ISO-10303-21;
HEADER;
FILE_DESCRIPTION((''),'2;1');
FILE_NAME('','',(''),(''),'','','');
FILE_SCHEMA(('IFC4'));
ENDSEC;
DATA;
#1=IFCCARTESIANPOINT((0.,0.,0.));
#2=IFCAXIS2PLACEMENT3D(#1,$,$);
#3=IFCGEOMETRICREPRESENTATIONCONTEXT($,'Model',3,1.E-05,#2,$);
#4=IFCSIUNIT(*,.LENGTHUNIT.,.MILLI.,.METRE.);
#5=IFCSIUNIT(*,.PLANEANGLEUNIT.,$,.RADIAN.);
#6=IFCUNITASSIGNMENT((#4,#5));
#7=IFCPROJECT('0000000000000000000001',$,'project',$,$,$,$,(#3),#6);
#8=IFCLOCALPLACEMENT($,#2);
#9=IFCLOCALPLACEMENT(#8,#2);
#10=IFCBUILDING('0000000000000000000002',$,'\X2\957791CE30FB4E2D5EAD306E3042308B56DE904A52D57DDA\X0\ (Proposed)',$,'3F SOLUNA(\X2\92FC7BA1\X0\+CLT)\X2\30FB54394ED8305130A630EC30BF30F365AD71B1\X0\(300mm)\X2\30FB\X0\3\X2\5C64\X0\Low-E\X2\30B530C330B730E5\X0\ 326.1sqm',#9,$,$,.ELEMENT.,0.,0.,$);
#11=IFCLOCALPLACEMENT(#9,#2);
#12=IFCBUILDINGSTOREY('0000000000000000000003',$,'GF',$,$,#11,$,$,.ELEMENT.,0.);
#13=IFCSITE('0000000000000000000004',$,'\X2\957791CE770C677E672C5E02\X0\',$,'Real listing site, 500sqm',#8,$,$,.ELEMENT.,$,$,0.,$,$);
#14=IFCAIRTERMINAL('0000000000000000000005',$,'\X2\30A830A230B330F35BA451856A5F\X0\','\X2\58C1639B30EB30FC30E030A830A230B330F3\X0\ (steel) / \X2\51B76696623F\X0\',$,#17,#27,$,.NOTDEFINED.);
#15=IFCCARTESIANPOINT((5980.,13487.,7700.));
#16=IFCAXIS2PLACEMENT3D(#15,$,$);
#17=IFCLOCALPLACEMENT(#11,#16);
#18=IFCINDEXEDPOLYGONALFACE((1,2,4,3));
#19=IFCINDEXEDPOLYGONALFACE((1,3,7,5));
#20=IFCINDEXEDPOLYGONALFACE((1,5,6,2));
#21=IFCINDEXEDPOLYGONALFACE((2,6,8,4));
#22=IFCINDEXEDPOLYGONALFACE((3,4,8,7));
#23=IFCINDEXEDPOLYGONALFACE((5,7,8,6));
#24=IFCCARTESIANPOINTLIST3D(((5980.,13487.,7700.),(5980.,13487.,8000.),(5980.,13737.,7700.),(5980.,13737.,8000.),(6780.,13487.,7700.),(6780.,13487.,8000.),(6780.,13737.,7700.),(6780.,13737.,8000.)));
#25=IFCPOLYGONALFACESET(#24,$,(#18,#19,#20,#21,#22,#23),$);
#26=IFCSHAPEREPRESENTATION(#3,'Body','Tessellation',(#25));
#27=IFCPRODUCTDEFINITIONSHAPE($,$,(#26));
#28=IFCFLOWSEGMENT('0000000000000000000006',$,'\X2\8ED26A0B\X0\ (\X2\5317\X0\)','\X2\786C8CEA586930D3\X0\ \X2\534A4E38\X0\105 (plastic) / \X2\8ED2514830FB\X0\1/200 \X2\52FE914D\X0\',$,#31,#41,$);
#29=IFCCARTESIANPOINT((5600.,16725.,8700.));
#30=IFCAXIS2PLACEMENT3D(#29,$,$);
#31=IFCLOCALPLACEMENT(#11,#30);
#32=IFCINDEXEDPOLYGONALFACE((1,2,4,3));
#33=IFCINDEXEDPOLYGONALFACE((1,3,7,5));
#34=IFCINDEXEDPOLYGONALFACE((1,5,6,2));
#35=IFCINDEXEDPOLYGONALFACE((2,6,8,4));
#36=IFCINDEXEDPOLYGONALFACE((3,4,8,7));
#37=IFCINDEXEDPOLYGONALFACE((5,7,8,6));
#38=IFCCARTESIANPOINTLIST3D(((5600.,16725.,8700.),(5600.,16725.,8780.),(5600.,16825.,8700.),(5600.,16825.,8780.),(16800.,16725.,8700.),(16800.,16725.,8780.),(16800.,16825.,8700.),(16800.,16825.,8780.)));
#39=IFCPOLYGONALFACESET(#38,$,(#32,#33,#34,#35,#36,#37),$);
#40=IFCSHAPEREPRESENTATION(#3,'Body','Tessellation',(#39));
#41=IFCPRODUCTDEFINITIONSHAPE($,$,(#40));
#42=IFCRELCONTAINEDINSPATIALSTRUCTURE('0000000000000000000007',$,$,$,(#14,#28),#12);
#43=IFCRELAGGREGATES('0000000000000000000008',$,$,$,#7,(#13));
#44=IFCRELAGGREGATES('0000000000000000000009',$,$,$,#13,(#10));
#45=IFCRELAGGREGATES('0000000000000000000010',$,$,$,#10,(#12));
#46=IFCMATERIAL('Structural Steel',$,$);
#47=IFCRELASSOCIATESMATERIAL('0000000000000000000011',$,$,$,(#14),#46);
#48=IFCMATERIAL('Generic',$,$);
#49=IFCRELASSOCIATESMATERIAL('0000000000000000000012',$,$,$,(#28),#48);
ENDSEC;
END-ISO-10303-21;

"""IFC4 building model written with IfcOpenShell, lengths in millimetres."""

from ifc_helpers import new_model, si_unit, frame, frame_2d, origin, place, context, project, spatial, rectangle, extrude, material, element, save


model = new_model("IFC4")

# Units and contexts
model_context = context("Model", 3, precision=1e-05, world=origin())
ifc_project = project(units=[si_unit("LENGTHUNIT", "METRE", prefix="MILLI"), si_unit("PLANEANGLEUNIT", "RADIAN")], contexts=[model_context])

# Site, building, storey
site_placement = place(None, origin())
site = spatial("IfcSite", under=ifc_project, at=site_placement, Name="長野県松本市", ObjectType="Real listing site, 500sqm", CompositionType="ELEMENT", RefElevation=0.0)
building_placement = place(site_placement, origin())
building = spatial("IfcBuilding", under=site, at=building_placement, Name="長野・中庭のある回遊動線 (Proposed)", ObjectType="3F SOLUNA(鋼管+CLT)・吹付けウレタン断熱(300mm)・3層Low-Eサッシュ 326.1sqm", CompositionType="ELEMENT", ElevationOfRefHeight=0.0, ElevationOfTerrain=0.0)
storey_placement = place(building_placement, origin())
storey = spatial("IfcBuildingStorey", under=building, at=storey_placement, Name="GF", CompositionType="ELEMENT", Elevation=0.0)

# Shared definitions
ifc_material_1 = material(Name="Structural Steel")

# Shared definitions
ifc_material_2 = material(Name="Generic")

# Air terminal
air_terminal_1_placement = place(storey_placement, frame((5980.0, 13487.0, 7700.0)))
element("IfcAirTerminal", 1, at=air_terminal_1_placement, inside=storey, material=ifc_material_1, Name="エアコン室内機", Description="壁掛ルームエアコン (steel) / 冷暖房", PredefinedType="NOTDEFINED", context=model_context, shape_type="SweptSolid", body=[
    extrude(rectangle(XDim=800.0, YDim=250.0, at=frame_2d((400.0, 125.0))), frame((5980.0, 13487.0, 7700.0)), (0.0, 0.0, 1.0), 300.0),
])

# Flow segment
flow_segment_placement = place(storey_placement, frame((5600.0, 16725.0, 8700.0)))
element("IfcFlowSegment", 2, at=flow_segment_placement, inside=storey, material=ifc_material_2, Name="軒樋 (北)", Description="硬質塩ビ 半丸105 (plastic) / 軒先・1/200 勾配", context=model_context, shape_type="SweptSolid", body=[
    extrude(rectangle(XDim=11200.0, YDim=100.0, at=frame_2d((5600.0, 50.0))), frame((5600.0, 16725.0, 8700.0)), (0.0, 0.0, 1.0), 80.0),
])

save(model, "model.ifc")
